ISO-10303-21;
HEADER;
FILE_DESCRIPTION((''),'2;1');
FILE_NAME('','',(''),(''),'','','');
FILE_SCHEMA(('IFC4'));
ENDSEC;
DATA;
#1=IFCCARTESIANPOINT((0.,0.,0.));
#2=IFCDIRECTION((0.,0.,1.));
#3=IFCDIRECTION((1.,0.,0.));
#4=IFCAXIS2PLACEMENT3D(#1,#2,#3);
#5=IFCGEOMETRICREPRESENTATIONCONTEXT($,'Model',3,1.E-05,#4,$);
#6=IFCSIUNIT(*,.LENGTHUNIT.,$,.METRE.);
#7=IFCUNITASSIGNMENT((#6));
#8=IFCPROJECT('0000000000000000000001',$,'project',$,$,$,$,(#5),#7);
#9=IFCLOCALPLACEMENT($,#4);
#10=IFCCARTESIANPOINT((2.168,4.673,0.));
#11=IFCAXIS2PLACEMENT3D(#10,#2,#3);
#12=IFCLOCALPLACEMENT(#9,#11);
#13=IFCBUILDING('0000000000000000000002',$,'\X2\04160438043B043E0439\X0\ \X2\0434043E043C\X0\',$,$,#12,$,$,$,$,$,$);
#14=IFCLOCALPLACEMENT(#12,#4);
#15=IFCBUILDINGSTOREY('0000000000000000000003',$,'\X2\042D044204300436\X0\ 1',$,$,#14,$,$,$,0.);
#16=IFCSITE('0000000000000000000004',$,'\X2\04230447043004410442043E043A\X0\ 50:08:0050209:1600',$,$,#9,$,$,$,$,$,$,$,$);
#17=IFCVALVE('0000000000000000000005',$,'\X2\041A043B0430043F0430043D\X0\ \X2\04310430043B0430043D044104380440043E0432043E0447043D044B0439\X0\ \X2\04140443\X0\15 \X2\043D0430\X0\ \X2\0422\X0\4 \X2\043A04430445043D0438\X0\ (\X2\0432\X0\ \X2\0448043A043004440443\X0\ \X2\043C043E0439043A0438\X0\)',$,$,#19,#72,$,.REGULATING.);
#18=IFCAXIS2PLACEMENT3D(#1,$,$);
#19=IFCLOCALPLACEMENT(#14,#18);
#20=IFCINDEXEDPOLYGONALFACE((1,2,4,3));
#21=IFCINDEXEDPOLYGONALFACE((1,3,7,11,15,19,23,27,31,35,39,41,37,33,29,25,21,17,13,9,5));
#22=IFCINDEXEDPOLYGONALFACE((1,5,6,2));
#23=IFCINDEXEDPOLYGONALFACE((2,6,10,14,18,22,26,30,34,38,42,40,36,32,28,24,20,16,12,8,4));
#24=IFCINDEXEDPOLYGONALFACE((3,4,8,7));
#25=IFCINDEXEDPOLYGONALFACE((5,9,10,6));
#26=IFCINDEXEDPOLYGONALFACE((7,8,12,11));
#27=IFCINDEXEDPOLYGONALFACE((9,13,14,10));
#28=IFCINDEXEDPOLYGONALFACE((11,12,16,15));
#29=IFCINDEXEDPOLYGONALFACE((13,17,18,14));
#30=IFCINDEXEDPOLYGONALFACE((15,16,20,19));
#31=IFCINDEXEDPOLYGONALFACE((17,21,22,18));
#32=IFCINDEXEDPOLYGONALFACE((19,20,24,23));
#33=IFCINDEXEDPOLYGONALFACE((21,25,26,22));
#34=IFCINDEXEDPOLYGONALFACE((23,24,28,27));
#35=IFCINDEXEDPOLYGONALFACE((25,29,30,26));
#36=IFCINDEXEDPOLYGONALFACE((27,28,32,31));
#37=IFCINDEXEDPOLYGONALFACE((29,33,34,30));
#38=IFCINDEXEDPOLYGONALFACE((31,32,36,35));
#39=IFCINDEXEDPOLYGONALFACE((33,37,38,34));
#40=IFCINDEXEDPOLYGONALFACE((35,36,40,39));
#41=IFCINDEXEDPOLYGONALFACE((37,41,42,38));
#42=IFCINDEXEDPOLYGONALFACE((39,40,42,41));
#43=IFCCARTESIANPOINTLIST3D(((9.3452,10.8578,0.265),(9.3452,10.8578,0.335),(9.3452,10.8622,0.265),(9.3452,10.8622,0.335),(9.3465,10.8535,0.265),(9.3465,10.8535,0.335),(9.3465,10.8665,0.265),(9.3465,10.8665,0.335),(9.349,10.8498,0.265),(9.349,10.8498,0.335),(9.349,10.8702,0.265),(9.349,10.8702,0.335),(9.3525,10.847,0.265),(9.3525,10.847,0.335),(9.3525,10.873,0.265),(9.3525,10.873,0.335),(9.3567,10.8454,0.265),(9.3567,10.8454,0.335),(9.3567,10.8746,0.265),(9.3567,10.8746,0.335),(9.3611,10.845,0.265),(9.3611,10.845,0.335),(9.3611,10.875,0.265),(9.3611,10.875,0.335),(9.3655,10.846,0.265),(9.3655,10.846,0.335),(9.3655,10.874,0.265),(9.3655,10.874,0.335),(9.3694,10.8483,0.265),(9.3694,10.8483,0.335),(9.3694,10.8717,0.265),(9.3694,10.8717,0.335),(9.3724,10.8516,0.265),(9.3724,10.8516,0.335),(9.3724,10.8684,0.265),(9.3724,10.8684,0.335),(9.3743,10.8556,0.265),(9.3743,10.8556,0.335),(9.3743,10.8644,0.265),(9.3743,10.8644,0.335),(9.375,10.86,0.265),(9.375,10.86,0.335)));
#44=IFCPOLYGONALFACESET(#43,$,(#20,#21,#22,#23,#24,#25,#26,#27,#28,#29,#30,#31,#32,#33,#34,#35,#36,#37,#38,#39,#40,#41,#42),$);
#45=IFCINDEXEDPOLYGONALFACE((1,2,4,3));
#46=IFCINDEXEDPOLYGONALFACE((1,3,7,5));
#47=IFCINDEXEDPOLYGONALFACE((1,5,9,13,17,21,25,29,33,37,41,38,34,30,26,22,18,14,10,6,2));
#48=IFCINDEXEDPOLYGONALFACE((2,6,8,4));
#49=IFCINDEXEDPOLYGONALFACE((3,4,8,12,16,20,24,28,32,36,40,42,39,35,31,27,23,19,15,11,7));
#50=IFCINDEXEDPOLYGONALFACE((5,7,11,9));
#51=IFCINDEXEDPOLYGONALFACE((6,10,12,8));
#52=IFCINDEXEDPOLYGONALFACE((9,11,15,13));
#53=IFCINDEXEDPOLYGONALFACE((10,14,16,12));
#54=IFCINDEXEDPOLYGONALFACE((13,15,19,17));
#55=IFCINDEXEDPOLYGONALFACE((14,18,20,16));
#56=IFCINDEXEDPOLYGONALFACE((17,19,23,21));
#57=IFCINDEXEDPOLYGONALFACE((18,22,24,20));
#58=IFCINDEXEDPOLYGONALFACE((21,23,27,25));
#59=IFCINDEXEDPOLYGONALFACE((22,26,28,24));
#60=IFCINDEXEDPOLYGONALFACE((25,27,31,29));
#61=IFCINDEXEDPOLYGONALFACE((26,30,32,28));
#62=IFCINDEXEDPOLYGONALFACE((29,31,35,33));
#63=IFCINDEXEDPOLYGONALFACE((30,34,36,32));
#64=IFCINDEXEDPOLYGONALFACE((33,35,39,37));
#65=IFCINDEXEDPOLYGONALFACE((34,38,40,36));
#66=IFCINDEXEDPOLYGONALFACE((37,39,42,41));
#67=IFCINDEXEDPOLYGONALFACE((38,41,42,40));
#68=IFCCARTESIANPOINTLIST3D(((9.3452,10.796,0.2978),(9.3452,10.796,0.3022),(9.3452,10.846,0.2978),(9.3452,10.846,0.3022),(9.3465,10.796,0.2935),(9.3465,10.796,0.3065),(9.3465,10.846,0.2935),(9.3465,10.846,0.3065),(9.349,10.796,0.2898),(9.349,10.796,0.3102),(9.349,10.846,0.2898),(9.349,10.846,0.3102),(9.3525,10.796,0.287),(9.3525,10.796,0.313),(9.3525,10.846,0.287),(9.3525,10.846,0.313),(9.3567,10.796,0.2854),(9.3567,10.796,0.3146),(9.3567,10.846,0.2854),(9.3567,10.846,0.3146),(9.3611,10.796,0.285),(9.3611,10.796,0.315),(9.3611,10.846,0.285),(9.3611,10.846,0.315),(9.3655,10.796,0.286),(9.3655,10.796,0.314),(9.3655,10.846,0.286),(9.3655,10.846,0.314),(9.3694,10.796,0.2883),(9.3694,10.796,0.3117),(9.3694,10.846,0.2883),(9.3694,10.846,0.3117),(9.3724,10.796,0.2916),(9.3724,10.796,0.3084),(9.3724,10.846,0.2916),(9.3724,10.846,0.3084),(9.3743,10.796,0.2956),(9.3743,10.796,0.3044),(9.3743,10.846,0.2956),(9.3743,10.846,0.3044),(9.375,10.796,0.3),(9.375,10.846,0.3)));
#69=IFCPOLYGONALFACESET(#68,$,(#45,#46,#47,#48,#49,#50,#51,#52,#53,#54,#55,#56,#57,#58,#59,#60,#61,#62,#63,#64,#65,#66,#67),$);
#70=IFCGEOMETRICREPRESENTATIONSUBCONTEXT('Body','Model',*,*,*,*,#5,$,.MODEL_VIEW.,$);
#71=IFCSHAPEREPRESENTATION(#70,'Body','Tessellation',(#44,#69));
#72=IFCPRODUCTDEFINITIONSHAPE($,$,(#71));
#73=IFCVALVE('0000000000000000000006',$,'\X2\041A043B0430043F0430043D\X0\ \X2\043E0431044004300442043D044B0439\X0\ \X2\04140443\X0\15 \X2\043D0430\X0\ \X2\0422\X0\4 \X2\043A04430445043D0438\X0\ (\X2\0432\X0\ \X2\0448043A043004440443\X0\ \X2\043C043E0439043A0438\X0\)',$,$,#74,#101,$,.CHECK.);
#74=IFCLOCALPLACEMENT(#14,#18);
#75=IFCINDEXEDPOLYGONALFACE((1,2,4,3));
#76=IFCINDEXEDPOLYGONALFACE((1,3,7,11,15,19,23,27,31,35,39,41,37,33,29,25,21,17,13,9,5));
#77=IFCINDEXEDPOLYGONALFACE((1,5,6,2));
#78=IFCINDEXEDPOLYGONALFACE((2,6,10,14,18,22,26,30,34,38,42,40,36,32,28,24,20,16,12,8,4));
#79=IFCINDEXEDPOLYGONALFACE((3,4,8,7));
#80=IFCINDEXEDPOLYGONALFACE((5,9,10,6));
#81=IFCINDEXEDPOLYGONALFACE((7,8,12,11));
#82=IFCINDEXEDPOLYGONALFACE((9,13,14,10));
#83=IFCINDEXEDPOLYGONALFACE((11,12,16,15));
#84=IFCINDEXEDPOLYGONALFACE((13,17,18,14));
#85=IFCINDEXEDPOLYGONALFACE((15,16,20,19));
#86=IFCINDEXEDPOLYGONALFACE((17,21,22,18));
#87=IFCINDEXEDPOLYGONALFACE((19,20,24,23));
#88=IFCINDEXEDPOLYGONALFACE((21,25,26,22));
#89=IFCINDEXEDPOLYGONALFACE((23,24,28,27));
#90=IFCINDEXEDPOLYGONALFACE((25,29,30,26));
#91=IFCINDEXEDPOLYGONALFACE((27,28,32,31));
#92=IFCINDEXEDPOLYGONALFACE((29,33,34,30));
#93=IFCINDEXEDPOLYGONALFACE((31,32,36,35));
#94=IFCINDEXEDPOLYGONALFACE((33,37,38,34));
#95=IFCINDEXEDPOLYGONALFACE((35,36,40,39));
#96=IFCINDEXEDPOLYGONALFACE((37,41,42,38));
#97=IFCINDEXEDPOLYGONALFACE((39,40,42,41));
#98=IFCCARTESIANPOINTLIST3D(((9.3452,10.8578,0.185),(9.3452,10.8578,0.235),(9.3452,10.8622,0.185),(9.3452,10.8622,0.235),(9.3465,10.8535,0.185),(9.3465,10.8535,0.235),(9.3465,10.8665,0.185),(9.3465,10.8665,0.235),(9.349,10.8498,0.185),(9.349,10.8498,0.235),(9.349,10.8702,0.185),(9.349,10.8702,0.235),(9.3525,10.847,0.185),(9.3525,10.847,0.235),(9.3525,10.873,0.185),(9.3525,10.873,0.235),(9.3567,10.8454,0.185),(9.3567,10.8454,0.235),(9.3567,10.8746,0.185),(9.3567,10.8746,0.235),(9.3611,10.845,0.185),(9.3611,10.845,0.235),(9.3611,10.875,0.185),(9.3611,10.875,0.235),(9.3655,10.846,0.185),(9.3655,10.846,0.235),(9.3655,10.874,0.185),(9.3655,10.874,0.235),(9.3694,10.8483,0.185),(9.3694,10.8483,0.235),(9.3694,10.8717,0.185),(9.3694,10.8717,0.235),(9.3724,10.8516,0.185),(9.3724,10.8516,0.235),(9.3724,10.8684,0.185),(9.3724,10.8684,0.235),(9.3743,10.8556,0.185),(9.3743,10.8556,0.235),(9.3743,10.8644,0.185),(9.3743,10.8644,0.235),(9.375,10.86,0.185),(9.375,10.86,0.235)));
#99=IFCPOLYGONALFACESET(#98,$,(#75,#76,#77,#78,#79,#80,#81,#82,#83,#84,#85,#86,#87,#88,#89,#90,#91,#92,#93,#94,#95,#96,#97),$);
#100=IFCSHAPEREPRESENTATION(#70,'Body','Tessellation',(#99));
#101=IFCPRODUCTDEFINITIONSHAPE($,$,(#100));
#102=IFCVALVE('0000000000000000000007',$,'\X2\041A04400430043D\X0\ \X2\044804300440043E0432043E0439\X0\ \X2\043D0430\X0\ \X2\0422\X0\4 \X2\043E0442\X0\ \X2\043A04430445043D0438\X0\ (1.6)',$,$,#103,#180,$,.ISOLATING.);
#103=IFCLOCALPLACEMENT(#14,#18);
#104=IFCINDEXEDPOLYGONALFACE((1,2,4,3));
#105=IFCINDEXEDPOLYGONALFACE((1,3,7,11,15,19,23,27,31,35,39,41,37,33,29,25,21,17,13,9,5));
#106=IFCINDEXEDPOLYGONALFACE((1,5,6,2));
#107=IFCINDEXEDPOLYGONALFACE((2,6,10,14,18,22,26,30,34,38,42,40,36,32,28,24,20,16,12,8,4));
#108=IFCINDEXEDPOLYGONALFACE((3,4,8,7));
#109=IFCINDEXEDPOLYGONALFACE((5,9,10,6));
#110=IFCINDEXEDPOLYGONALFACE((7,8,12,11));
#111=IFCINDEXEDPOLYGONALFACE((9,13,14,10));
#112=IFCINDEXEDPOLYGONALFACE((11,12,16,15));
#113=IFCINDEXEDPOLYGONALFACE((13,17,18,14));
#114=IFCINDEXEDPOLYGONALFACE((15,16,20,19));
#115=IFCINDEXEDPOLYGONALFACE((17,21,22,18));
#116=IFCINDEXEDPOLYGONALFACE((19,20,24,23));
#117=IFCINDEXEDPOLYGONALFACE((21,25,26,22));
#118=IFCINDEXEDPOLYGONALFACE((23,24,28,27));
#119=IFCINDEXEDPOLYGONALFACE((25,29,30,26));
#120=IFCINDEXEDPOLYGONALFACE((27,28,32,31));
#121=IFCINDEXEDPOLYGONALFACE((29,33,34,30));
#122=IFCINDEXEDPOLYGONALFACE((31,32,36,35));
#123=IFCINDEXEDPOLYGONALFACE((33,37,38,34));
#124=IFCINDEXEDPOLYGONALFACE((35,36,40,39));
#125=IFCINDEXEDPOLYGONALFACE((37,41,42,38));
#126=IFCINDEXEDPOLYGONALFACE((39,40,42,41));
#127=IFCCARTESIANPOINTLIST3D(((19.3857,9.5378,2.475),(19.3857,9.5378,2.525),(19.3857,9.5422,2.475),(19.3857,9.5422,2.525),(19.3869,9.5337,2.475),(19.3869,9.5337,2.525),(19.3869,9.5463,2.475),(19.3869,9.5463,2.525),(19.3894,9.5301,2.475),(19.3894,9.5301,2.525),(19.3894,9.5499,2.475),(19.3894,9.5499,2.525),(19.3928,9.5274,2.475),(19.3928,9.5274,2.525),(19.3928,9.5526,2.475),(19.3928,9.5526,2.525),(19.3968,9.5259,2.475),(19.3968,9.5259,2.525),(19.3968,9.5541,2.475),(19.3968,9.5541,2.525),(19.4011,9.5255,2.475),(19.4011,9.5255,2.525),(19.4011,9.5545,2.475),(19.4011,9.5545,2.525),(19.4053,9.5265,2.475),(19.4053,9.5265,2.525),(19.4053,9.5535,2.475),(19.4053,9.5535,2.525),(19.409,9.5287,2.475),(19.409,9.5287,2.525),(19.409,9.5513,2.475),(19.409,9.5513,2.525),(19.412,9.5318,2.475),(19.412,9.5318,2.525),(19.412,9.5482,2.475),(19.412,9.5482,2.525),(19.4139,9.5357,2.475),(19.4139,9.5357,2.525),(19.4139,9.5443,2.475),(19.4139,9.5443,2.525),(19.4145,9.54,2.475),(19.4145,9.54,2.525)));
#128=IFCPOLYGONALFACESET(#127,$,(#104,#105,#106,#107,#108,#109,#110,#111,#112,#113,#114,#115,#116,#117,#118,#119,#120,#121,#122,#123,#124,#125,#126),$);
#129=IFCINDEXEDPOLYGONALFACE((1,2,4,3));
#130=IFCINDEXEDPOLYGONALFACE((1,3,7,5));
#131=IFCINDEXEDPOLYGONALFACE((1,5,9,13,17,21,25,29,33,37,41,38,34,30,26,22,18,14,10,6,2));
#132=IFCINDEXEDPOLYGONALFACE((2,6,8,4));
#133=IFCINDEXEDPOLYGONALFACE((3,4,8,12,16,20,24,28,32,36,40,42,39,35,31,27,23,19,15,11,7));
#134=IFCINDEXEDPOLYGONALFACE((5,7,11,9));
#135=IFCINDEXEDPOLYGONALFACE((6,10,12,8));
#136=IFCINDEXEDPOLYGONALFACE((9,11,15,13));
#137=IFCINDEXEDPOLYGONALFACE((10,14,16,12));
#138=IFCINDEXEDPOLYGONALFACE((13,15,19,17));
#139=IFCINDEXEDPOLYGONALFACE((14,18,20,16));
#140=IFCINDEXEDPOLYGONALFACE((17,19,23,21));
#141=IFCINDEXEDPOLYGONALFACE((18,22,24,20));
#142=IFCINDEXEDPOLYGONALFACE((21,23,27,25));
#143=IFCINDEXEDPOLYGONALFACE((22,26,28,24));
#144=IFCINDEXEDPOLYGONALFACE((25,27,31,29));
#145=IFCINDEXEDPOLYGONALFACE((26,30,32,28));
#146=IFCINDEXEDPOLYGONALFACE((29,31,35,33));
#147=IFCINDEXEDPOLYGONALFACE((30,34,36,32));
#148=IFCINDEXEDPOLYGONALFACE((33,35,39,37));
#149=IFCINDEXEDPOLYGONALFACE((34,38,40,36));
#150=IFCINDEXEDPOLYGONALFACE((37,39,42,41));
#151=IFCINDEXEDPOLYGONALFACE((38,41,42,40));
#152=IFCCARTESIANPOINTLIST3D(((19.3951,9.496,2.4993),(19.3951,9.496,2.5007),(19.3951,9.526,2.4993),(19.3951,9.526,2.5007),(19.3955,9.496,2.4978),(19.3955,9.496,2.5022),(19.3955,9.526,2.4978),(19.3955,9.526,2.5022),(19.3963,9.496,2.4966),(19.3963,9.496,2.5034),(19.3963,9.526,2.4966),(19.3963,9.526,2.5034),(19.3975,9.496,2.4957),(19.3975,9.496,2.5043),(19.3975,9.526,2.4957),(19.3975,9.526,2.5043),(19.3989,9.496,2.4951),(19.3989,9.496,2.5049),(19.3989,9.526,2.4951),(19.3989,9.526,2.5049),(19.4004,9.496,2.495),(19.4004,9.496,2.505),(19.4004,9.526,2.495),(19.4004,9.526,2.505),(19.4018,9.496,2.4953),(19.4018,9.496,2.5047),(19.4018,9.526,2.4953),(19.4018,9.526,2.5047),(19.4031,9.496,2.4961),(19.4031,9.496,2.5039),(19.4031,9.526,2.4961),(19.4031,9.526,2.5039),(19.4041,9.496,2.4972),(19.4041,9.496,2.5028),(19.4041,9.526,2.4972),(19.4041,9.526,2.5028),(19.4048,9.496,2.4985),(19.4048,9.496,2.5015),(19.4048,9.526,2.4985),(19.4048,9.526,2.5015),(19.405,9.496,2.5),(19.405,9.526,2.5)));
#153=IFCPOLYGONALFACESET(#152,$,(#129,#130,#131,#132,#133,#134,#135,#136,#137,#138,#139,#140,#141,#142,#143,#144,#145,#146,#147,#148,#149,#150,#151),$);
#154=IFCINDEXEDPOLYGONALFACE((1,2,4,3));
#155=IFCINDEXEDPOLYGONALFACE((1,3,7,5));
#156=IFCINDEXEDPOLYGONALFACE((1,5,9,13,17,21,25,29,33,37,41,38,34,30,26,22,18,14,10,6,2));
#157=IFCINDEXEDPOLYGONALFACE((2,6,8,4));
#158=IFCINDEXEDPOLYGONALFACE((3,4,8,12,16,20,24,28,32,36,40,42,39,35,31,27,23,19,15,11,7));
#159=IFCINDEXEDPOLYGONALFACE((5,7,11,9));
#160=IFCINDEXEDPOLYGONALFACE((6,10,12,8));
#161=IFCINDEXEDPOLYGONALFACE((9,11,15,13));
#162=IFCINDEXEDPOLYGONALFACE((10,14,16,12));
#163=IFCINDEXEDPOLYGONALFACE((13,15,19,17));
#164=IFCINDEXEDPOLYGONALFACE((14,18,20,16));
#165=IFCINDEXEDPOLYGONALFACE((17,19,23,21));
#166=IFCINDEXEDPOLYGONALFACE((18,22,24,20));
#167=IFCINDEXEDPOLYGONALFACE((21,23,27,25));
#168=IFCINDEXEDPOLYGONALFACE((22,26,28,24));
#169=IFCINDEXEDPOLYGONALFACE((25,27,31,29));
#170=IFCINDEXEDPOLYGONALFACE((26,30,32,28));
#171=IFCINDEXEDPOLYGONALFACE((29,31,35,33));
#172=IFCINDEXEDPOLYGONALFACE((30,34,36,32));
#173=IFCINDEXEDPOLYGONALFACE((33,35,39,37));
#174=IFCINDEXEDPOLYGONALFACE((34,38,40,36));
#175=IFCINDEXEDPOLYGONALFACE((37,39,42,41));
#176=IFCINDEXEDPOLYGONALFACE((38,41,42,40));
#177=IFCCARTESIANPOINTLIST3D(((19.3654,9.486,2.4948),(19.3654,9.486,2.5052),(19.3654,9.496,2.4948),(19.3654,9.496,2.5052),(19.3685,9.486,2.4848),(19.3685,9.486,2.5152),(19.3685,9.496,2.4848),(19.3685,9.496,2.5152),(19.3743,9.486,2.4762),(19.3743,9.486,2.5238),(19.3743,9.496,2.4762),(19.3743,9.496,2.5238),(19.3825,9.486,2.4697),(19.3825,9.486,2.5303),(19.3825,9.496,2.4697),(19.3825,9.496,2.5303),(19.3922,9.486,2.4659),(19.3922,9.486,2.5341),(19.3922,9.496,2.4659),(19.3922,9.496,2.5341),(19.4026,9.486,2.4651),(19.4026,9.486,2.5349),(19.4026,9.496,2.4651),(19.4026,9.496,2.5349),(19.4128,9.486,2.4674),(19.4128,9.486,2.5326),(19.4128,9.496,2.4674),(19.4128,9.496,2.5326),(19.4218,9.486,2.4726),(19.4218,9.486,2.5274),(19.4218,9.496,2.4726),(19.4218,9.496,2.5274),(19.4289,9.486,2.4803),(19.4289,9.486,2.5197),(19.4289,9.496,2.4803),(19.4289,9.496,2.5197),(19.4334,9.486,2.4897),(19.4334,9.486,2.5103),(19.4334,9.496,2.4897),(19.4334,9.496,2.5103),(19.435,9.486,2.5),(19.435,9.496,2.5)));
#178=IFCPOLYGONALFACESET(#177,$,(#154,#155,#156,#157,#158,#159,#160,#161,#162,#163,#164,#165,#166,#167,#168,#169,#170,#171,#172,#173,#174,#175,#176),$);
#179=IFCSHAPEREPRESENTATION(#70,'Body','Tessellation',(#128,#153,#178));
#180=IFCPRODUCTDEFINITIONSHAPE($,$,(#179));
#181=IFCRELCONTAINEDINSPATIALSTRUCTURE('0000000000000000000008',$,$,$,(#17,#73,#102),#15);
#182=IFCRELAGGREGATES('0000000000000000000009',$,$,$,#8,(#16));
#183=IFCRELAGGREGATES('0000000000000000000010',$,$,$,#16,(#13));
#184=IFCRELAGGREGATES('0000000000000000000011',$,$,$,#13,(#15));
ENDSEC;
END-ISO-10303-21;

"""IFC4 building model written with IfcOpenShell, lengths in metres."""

from ifc_helpers import new_model, si_unit, frame, origin_with_axes, origin_2d, place, context, subcontext, project, spatial, circle, extrude, element, save


model = new_model("IFC4")

# Units and contexts
model_context = context("Model", 3, precision=1e-05, world=origin_with_axes())
body_context = subcontext(model_context, "Body", "Model", "MODEL_VIEW")
ifc_project = project(units=[si_unit("LENGTHUNIT", "METRE")], contexts=[model_context])

# Site, building, storey
site_placement = place(None, origin_with_axes())
site = spatial("IfcSite", under=ifc_project, at=site_placement, Name="Участок 50:08:0050209:1600")
building_placement = place(site_placement, frame((2.168, 4.673, 0.0), z_axis=(0.0, 0.0, 1.0), x_axis=(1.0, 0.0, 0.0)))
building = spatial("IfcBuilding", under=site, at=building_placement, Name="Жилой дом")
storey_placement = place(building_placement, origin_with_axes())
storey = spatial("IfcBuildingStorey", under=building, at=storey_placement, Name="Этаж 1", Elevation=0.0)

# Valves
valve_1_placement = place(storey_placement, origin_with_axes())
element("IfcValve", 1, at=valve_1_placement, inside=storey, Name="Клапан балансировочный Ду15 на Т4 кухни (в шкафу мойки)", PredefinedType="REGULATING", context=body_context, shape_type="SweptSolid", body=[
    extrude(circle(Radius=0.015, at=origin_2d()), frame((9.36, 10.86, 0.265), z_axis=(0.0, 0.0, 1.0), x_axis=(1.0, 0.0, 0.0)), (0.0, 0.0, 1.0), 0.07),
    extrude(circle(Radius=0.015, at=origin_2d()), frame((9.36, 10.846, 0.3), z_axis=(0.0, -1.0, 0.0), x_axis=(1.0, 0.0, 0.0)), (0.0, 0.0, 1.0), 0.05),
])
valve_2_placement = place(storey_placement, origin_with_axes())
element("IfcValve", 2, at=valve_2_placement, inside=storey, Name="Клапан обратный Ду15 на Т4 кухни (в шкафу мойки)", PredefinedType="CHECK", context=body_context, shape_type="SweptSolid", body=[
    extrude(circle(Radius=0.015, at=origin_2d()), frame((9.36, 10.86, 0.185), z_axis=(0.0, 0.0, 1.0), x_axis=(1.0, 0.0, 0.0)), (0.0, 0.0, 1.0), 0.05),
])
valve_3_placement = place(storey_placement, origin_with_axes())
element("IfcValve", 3, at=valve_3_placement, inside=storey, Name="Кран шаровой на Т4 от кухни (1.6)", PredefinedType="ISOLATING", context=body_context, shape_type="SweptSolid", body=[
    extrude(circle(Radius=0.0145, at=origin_2d()), frame((19.4, 9.54, 2.475), z_axis=(0.0, 0.0, 1.0), x_axis=(1.0, 0.0, 0.0)), (0.0, 0.0, 1.0), 0.05),
    extrude(circle(Radius=0.005, at=origin_2d()), frame((19.4, 9.526, 2.5), z_axis=(0.0, -1.0, 0.0), x_axis=(1.0, 0.0, 0.0)), (0.0, 0.0, 1.0), 0.03),
    extrude(circle(Radius=0.035, at=origin_2d()), frame((19.4, 9.496, 2.5), z_axis=(0.0, -1.0, 0.0), x_axis=(1.0, 0.0, 0.0)), (0.0, 0.0, 1.0), 0.01),
])

save(model, "model.ifc")
